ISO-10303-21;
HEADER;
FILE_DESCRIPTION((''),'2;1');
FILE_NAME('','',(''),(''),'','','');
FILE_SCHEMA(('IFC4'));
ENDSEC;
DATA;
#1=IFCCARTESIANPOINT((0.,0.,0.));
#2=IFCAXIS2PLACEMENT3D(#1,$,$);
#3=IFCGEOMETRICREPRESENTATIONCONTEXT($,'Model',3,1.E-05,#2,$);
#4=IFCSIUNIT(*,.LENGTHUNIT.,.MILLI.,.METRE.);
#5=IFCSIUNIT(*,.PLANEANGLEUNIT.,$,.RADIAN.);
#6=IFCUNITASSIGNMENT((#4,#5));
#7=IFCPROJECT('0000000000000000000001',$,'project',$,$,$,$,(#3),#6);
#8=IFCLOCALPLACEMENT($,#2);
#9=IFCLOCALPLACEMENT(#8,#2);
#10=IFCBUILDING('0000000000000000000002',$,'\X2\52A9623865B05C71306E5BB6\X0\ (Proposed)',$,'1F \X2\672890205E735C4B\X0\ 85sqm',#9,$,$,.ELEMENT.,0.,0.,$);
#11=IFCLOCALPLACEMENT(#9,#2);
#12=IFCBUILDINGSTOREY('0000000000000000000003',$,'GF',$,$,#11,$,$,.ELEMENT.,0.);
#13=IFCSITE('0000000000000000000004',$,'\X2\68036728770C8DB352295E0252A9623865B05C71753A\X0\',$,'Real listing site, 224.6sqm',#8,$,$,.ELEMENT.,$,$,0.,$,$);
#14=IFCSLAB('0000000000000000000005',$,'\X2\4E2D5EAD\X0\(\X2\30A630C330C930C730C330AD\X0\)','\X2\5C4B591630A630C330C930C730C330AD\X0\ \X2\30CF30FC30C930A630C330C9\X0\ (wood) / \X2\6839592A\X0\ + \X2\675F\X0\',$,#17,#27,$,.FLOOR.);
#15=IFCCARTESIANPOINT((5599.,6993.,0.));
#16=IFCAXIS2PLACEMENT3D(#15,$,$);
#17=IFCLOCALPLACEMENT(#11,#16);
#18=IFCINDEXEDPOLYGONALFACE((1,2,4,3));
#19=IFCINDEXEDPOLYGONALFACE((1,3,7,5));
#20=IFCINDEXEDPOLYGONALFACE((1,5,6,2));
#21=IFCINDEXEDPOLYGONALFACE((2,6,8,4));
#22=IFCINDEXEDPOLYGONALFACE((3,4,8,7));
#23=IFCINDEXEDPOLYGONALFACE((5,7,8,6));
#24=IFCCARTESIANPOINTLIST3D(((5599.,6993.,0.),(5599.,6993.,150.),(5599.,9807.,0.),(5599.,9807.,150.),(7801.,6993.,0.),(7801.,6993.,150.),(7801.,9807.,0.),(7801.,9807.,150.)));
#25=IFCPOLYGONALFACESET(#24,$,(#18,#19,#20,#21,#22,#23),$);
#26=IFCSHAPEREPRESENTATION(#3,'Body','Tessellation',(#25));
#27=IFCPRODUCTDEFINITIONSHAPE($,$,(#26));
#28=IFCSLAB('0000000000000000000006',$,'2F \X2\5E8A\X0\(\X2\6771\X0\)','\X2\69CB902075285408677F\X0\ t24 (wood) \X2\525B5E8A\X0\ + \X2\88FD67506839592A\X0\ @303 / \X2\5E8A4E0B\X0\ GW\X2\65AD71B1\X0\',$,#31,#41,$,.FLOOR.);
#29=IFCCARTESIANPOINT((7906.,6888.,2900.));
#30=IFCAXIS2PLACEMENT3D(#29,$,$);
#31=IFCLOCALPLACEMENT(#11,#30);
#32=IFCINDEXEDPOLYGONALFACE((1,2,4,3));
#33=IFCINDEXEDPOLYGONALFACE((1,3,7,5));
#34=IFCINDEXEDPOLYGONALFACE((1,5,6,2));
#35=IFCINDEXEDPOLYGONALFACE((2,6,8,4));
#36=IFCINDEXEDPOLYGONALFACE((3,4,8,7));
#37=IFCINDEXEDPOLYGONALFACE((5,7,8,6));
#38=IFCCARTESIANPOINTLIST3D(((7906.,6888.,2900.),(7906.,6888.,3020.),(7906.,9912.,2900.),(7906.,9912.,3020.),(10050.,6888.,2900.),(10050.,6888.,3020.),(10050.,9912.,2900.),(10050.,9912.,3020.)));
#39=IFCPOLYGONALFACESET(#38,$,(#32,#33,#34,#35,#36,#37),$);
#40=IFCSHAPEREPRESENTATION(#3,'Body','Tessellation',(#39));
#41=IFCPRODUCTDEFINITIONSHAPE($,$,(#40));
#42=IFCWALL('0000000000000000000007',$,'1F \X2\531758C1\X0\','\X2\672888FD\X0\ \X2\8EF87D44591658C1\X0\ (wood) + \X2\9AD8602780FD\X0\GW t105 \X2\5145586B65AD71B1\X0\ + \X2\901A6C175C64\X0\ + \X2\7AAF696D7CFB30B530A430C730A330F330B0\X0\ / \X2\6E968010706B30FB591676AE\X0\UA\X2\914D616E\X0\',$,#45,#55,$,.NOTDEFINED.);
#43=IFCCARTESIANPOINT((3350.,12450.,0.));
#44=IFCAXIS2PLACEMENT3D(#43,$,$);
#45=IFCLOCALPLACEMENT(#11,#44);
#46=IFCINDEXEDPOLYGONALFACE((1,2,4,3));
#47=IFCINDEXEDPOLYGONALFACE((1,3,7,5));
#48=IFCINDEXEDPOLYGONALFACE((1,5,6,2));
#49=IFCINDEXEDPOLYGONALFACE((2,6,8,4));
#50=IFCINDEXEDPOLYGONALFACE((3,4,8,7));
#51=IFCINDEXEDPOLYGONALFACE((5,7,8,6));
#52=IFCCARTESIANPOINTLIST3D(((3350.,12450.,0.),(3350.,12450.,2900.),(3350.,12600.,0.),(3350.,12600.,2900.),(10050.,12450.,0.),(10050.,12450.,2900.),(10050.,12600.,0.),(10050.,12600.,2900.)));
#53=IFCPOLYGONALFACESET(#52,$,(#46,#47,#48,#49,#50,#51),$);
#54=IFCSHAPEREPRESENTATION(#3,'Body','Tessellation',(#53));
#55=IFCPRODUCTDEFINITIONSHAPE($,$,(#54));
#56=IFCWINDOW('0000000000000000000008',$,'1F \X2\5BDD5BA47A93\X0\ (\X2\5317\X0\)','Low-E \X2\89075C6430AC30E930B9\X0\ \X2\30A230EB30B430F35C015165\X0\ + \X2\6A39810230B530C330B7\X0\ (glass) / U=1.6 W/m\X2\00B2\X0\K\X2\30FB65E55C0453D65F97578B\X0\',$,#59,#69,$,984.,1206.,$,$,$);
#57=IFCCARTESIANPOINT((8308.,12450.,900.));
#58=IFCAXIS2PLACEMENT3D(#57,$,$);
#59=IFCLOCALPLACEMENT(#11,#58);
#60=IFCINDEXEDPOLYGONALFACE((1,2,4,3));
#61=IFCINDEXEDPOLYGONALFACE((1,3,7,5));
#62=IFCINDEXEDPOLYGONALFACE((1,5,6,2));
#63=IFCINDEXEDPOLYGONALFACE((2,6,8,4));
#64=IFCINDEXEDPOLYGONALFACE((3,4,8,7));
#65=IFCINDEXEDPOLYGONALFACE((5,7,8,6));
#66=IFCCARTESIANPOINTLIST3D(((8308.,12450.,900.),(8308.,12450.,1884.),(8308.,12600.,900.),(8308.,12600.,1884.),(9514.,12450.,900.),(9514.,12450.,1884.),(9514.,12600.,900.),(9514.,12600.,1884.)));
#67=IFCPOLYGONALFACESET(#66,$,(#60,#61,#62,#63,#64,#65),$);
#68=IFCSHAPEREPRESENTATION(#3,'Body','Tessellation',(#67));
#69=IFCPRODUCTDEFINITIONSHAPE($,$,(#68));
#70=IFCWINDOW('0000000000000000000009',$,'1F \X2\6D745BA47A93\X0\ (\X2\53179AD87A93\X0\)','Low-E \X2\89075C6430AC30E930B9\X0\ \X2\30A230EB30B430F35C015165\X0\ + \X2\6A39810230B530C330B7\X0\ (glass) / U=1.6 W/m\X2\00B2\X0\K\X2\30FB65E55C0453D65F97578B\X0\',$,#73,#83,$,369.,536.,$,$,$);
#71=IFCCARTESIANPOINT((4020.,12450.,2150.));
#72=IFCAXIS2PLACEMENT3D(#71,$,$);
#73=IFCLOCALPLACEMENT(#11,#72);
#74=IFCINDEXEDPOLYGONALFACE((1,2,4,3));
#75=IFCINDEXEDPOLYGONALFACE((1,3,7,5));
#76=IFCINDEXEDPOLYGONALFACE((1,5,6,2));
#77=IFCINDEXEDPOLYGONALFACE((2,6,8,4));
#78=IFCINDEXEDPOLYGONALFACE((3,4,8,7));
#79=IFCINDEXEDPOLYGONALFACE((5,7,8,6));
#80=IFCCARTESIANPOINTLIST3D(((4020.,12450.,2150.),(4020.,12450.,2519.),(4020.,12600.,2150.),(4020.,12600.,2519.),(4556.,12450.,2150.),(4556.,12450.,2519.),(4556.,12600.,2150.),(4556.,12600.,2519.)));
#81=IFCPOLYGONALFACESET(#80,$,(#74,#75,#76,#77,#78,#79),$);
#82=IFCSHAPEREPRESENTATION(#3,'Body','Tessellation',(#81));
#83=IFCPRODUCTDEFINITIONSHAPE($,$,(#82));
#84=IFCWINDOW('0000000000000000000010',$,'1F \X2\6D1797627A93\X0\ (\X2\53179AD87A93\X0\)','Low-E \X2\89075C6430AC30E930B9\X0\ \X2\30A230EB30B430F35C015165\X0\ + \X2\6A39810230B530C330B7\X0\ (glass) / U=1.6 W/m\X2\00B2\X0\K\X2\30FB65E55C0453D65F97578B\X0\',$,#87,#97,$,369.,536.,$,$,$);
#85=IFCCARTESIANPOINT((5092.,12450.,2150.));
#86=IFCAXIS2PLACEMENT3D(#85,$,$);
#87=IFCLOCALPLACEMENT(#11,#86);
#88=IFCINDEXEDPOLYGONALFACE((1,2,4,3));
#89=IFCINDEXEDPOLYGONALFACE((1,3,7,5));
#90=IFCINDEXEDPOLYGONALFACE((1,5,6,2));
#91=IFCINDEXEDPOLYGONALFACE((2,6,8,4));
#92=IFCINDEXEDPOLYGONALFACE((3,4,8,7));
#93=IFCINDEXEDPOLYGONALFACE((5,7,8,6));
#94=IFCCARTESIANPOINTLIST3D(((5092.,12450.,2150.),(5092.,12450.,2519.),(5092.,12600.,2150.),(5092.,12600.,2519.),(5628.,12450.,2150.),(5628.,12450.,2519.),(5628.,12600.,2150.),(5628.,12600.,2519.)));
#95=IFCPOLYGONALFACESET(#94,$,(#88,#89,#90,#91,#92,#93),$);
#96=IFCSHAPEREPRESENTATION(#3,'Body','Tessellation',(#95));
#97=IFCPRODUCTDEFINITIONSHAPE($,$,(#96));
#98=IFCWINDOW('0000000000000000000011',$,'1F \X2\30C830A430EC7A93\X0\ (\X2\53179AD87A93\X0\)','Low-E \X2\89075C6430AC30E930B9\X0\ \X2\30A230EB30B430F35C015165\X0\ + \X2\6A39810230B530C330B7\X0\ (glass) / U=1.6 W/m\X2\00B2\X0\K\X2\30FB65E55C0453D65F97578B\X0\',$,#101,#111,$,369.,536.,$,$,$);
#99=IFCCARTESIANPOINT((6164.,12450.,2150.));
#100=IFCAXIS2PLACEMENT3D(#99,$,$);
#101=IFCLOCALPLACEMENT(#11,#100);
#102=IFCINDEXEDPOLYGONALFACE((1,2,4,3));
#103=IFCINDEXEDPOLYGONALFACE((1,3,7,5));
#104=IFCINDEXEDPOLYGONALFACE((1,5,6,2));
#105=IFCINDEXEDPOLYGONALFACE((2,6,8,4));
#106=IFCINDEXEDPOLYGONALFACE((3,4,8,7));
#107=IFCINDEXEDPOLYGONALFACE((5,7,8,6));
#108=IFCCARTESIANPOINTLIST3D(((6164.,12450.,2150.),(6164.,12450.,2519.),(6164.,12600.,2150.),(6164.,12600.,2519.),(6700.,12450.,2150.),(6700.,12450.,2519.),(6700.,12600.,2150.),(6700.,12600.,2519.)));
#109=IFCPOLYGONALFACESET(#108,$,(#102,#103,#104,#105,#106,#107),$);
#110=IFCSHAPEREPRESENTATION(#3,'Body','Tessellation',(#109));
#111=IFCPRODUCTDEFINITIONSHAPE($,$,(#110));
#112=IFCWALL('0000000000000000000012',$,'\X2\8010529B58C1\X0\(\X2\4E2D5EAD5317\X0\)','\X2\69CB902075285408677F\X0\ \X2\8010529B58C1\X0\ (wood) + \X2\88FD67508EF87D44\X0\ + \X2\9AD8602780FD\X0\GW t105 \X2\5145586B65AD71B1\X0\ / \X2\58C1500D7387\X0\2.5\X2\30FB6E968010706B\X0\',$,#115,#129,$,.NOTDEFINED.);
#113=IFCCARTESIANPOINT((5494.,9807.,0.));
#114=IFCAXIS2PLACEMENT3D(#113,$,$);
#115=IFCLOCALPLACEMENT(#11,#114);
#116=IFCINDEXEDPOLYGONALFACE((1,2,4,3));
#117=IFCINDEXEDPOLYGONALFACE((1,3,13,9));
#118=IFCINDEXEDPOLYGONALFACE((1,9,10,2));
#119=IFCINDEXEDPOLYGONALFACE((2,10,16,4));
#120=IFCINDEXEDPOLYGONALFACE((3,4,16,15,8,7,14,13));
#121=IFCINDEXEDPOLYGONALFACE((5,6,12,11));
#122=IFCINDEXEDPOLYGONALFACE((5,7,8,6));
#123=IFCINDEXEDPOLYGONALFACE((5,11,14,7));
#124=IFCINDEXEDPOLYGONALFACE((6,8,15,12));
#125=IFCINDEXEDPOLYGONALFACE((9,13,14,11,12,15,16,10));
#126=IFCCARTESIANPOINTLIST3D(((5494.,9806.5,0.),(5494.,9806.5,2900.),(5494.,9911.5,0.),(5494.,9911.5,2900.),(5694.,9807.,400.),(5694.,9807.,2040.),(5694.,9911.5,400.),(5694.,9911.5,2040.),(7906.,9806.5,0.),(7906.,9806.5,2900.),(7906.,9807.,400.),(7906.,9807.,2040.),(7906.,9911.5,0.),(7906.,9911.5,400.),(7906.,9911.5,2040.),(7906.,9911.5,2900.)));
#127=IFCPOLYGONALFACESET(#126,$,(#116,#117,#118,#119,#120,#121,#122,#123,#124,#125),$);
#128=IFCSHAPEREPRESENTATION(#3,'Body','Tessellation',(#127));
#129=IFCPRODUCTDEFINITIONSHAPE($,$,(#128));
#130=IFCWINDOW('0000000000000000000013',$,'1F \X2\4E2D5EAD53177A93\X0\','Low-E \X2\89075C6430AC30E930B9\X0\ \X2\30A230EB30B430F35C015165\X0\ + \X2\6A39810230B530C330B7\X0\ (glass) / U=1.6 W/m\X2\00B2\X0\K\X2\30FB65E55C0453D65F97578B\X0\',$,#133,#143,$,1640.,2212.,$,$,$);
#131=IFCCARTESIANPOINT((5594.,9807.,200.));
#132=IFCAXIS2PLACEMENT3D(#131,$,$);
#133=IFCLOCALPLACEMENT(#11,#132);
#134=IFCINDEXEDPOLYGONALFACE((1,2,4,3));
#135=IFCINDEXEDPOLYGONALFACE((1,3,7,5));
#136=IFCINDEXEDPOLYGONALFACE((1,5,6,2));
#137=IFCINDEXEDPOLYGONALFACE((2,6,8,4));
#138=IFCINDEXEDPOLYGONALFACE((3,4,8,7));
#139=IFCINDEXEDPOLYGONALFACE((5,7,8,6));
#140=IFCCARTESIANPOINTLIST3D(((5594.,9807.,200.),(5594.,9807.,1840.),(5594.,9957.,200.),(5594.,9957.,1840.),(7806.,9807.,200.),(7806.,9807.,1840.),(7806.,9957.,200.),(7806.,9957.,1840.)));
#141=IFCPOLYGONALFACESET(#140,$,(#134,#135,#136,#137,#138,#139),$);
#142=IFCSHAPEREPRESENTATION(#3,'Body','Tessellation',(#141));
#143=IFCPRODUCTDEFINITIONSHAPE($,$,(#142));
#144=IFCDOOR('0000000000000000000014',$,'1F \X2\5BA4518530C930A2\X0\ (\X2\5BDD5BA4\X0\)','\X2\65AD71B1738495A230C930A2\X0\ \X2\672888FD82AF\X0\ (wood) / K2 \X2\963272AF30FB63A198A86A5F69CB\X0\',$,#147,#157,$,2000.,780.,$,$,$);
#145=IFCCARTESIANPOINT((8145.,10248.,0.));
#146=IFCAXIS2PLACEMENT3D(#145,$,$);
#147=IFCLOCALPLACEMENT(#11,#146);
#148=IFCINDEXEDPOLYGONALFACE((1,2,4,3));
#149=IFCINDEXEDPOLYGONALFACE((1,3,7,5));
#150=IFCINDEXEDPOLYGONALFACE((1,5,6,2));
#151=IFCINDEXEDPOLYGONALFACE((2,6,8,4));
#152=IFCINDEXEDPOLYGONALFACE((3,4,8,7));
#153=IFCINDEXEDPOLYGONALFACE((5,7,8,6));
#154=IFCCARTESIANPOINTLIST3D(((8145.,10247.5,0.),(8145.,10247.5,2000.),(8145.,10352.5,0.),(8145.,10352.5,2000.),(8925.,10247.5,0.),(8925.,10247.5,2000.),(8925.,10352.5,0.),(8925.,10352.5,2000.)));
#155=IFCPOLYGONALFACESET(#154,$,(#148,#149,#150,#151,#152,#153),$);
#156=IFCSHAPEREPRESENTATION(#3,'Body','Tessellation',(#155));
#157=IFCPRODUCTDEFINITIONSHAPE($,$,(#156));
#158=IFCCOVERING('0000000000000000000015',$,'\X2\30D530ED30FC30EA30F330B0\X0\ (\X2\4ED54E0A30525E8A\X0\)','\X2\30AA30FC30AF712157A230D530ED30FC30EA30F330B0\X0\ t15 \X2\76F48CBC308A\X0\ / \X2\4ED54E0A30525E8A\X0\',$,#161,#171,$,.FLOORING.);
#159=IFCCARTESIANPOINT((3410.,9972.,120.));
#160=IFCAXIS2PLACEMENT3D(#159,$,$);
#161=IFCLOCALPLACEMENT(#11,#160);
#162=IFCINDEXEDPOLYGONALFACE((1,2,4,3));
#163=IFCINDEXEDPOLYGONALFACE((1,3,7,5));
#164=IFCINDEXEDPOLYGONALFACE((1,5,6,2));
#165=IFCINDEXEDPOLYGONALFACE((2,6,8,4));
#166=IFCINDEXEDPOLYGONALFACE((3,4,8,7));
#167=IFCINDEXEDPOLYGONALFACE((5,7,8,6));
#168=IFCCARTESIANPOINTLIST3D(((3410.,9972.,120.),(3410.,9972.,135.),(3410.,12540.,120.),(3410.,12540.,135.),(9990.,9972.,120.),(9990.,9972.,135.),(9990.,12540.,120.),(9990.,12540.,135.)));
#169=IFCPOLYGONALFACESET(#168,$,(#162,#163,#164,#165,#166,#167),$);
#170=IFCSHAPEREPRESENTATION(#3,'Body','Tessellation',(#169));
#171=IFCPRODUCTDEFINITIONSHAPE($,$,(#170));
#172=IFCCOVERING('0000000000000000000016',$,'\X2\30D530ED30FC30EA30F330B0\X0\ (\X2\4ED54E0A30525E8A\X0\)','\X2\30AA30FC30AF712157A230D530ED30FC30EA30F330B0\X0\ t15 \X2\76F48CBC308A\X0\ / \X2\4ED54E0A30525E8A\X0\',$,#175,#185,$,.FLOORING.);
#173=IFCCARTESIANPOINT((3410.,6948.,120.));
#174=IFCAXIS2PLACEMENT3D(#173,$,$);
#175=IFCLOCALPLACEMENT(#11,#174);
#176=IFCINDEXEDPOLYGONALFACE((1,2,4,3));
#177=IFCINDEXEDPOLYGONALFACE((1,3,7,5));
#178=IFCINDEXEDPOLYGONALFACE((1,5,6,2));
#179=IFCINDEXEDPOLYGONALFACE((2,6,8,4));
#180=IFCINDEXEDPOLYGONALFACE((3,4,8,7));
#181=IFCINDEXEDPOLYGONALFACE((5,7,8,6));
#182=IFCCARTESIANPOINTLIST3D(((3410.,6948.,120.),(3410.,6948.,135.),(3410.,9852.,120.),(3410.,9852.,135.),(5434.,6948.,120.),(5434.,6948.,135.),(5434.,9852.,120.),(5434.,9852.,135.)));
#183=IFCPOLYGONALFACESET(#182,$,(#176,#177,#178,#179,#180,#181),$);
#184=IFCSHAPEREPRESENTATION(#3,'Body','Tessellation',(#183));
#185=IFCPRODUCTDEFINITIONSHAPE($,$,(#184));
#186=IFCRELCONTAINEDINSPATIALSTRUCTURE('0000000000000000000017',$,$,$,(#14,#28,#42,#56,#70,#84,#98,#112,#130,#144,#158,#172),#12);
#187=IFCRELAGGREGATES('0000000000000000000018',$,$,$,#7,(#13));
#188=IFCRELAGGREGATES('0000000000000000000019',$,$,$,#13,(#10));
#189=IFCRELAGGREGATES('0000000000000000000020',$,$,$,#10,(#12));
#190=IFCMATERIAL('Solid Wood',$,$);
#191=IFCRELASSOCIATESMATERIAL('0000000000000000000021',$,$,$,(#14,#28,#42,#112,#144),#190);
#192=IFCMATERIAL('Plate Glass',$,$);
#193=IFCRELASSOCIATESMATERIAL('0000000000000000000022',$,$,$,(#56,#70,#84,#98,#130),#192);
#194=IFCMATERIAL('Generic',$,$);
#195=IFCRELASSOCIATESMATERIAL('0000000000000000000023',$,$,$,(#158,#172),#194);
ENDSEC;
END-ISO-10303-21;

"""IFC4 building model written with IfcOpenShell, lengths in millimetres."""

from ifc_helpers import new_model, si_unit, frame, frame_2d, origin, place, context, project, spatial, rectangle, extrude, material, element, fill, save


model = new_model("IFC4")

# Units and contexts
model_context = context("Model", 3, precision=1e-05, world=origin())
ifc_project = project(units=[si_unit("LENGTHUNIT", "METRE", prefix="MILLI"), si_unit("PLANEANGLEUNIT", "RADIAN")], contexts=[model_context])

# Site, building, storey
site_placement = place(None, origin())
site = spatial("IfcSite", under=ifc_project, at=site_placement, Name="栃木県足利市助戸新山町", ObjectType="Real listing site, 224.6sqm", CompositionType="ELEMENT", RefElevation=0.0)
building_placement = place(site_placement, origin())
building = spatial("IfcBuilding", under=site, at=building_placement, Name="助戸新山の家 (Proposed)", ObjectType="1F 木造平屋 85sqm", CompositionType="ELEMENT", ElevationOfRefHeight=0.0, ElevationOfTerrain=0.0)
storey_placement = place(building_placement, origin())
storey = spatial("IfcBuildingStorey", under=building, at=storey_placement, Name="GF", CompositionType="ELEMENT", Elevation=0.0)

# Slabs
ifc_material_1 = material(Name="Solid Wood")
slab_1_placement = place(storey_placement, frame((5599.0, 6993.0, 0.0)))
element("IfcSlab", 1, at=slab_1_placement, inside=storey, material=ifc_material_1, Name="中庭(ウッドデッキ)", Description="屋外ウッドデッキ ハードウッド (wood) / 根太 + 束", PredefinedType="FLOOR", context=model_context, shape_type="SweptSolid", body=[
    extrude(rectangle(XDim=2202.0, YDim=2814.0, at=frame_2d((1101.0, 1407.0))), frame((5599.0, 6993.0, 0.0)), (0.0, 0.0, 1.0), 150.0),
])
slab_2_placement = place(storey_placement, frame((7906.0, 6888.0, 2900.0)))
element("IfcSlab", 2, at=slab_2_placement, inside=storey, material=ifc_material_1, Name="2F 床(東)", Description="構造用合板 t24 (wood) 剛床 + 製材根太 @303 / 床下 GW断熱", PredefinedType="FLOOR", context=model_context, shape_type="SweptSolid", body=[
    extrude(rectangle(XDim=2144.0, YDim=3024.0, at=frame_2d((1072.0, 1512.0))), frame((7906.0, 6888.0, 2900.0)), (0.0, 0.0, 1.0), 120.0),
])

# Wall, openings, windows
wall_1_placement = place(storey_placement, frame((3350.0, 12450.0, 0.0)))
wall_1 = element("IfcWall", 3, at=wall_1_placement, inside=storey, material=ifc_material_1, Name="1F 北壁", Description="木製 軸組外壁 (wood) + 高性能GW t105 充填断熱 + 通気層 + 窯業系サイディング / 準耐火・外皮UA配慮", PredefinedType="NOTDEFINED", context=model_context, shape_type="SweptSolid", body=[
    extrude(rectangle(XDim=6700.0, YDim=150.0, at=frame_2d((3350.0, 75.0))), frame((3350.0, 12450.0, 0.0)), (0.0, 0.0, 1.0), 2900.0),
])
opening_1_placement = place(storey_placement, frame((8308.0, 12450.0, 900.0)))
opening_1 = element("IfcOpeningElement", 4, at=opening_1_placement, cuts=wall_1, PredefinedType="NOTDEFINED", context=model_context, shape_type="SweptSolid", body=[
    extrude(rectangle(XDim=1206.0, YDim=150.0, at=frame_2d((603.0, 75.0))), frame((8308.0, 12450.0, 900.0)), (0.0, 0.0, 1.0), 984.0),
])
opening_2_placement = place(storey_placement, frame((4020.0, 12450.0, 2150.0)))
opening_2 = element("IfcOpeningElement", 5, at=opening_2_placement, cuts=wall_1, PredefinedType="NOTDEFINED", context=model_context, shape_type="SweptSolid", body=[
    extrude(rectangle(XDim=536.0, YDim=150.0, at=frame_2d((268.0, 75.0))), frame((4020.0, 12450.0, 2150.0)), (0.0, 0.0, 1.0), 369.0),
])
opening_3_placement = place(storey_placement, frame((5092.0, 12450.0, 2150.0)))
opening_3 = element("IfcOpeningElement", 6, at=opening_3_placement, cuts=wall_1, PredefinedType="NOTDEFINED", context=model_context, shape_type="SweptSolid", body=[
    extrude(rectangle(XDim=536.0, YDim=150.0, at=frame_2d((268.0, 75.0))), frame((5092.0, 12450.0, 2150.0)), (0.0, 0.0, 1.0), 369.0),
])
opening_4_placement = place(storey_placement, frame((6164.0, 12450.0, 2150.0)))
opening_4 = element("IfcOpeningElement", 7, at=opening_4_placement, cuts=wall_1, PredefinedType="NOTDEFINED", context=model_context, shape_type="SweptSolid", body=[
    extrude(rectangle(XDim=536.0, YDim=150.0, at=frame_2d((268.0, 75.0))), frame((6164.0, 12450.0, 2150.0)), (0.0, 0.0, 1.0), 369.0),
])
ifc_material_2 = material(Name="Plate Glass")
window_1_placement = place(storey_placement, frame((8308.0, 12450.0, 900.0)))
window_1 = element("IfcWindow", 8, at=window_1_placement, inside=storey, material=ifc_material_2, Name="1F 寝室窓 (北)", Description="Low-E 複層ガラス アルゴン封入 + 樹脂サッシ (glass) / U=1.6 W/m²K・日射取得型", OverallHeight=984.0, OverallWidth=1206.0, context=model_context, shape_type="SweptSolid", body=[
    extrude(rectangle(XDim=1206.0, YDim=150.0, at=frame_2d((603.0, 75.0))), frame((8308.0, 12450.0, 900.0)), (0.0, 0.0, 1.0), 984.0),
])
fill(opening_1, window_1)
window_2_placement = place(storey_placement, frame((4020.0, 12450.0, 2150.0)))
window_2 = element("IfcWindow", 9, at=window_2_placement, inside=storey, material=ifc_material_2, Name="1F 浴室窓 (北高窓)", Description="Low-E 複層ガラス アルゴン封入 + 樹脂サッシ (glass) / U=1.6 W/m²K・日射取得型", OverallHeight=369.0, OverallWidth=536.0, context=model_context, shape_type="SweptSolid", body=[
    extrude(rectangle(XDim=536.0, YDim=150.0, at=frame_2d((268.0, 75.0))), frame((4020.0, 12450.0, 2150.0)), (0.0, 0.0, 1.0), 369.0),
])
fill(opening_2, window_2)
window_3_placement = place(storey_placement, frame((5092.0, 12450.0, 2150.0)))
window_3 = element("IfcWindow", 10, at=window_3_placement, inside=storey, material=ifc_material_2, Name="1F 洗面窓 (北高窓)", Description="Low-E 複層ガラス アルゴン封入 + 樹脂サッシ (glass) / U=1.6 W/m²K・日射取得型", OverallHeight=369.0, OverallWidth=536.0, context=model_context, shape_type="SweptSolid", body=[
    extrude(rectangle(XDim=536.0, YDim=150.0, at=frame_2d((268.0, 75.0))), frame((5092.0, 12450.0, 2150.0)), (0.0, 0.0, 1.0), 369.0),
])
fill(opening_3, window_3)
window_4_placement = place(storey_placement, frame((6164.0, 12450.0, 2150.0)))
window_4 = element("IfcWindow", 11, at=window_4_placement, inside=storey, material=ifc_material_2, Name="1F トイレ窓 (北高窓)", Description="Low-E 複層ガラス アルゴン封入 + 樹脂サッシ (glass) / U=1.6 W/m²K・日射取得型", OverallHeight=369.0, OverallWidth=536.0, context=model_context, shape_type="SweptSolid", body=[
    extrude(rectangle(XDim=536.0, YDim=150.0, at=frame_2d((268.0, 75.0))), frame((6164.0, 12450.0, 2150.0)), (0.0, 0.0, 1.0), 369.0),
])
fill(opening_4, window_4)

# Wall, opening, window
wall_2_placement = place(storey_placement, frame((5494.0, 9807.0, 0.0)))
wall_2 = element("IfcWall", 12, at=wall_2_placement, inside=storey, material=ifc_material_1, Name="耐力壁(中庭北)", Description="構造用合板 耐力壁 (wood) + 製材軸組 + 高性能GW t105 充填断熱 / 壁倍率2.5・準耐火", PredefinedType="NOTDEFINED", context=model_context, shape_type="SweptSolid", body=[
    extrude(rectangle(XDim=2412.0, YDim=105.0, at=frame_2d((1206.0, 52.0))), frame((5494.0, 9807.0, 0.0)), (0.0, 0.0, 1.0), 2900.0),
])
opening_5_placement = place(storey_placement, frame((5594.0, 9807.0, 200.0)))
opening_5 = element("IfcOpeningElement", 13, at=opening_5_placement, cuts=wall_2, PredefinedType="NOTDEFINED", context=model_context, shape_type="SweptSolid", body=[
    extrude(rectangle(XDim=2212.0, YDim=150.0, at=frame_2d((1106.0, 75.0))), frame((5594.0, 9807.0, 200.0)), (0.0, 0.0, 1.0), 1640.0),
])
window_5_placement = place(storey_placement, frame((5594.0, 9807.0, 200.0)))
window_5 = element("IfcWindow", 14, at=window_5_placement, inside=storey, material=ifc_material_2, Name="1F 中庭北窓", Description="Low-E 複層ガラス アルゴン封入 + 樹脂サッシ (glass) / U=1.6 W/m²K・日射取得型", OverallHeight=1640.0, OverallWidth=2212.0, context=model_context, shape_type="SweptSolid", body=[
    extrude(rectangle(XDim=2212.0, YDim=150.0, at=frame_2d((1106.0, 75.0))), frame((5594.0, 9807.0, 200.0)), (0.0, 0.0, 1.0), 1640.0),
])
fill(opening_5, window_5)

# Door
door_1_placement = place(storey_placement, frame((8145.0, 10248.0, 0.0)))
element("IfcDoor", 15, at=door_1_placement, inside=storey, material=ifc_material_1, Name="1F 室内ドア (寝室)", Description="断熱玄関ドア 木製芯 (wood) / K2 防犯・採風機構", OverallHeight=2000.0, OverallWidth=780.0, context=model_context, shape_type="SweptSolid", body=[
    extrude(rectangle(XDim=780.0, YDim=105.0, at=frame_2d((390.0, 52.0))), frame((8145.0, 10248.0, 0.0)), (0.0, 0.0, 1.0), 2000.0),
])

# Coverings
ifc_material_3 = material(Name="Generic")
covering_1_placement = place(storey_placement, frame((3410.0, 9972.0, 120.0)))
element("IfcCovering", 16, at=covering_1_placement, inside=storey, material=ifc_material_3, Name="フローリング (仕上げ床)", Description="オーク無垢フローリング t15 直貼り / 仕上げ床", PredefinedType="FLOORING", context=model_context, shape_type="SweptSolid", body=[
    extrude(rectangle(XDim=6580.0, YDim=2568.0, at=frame_2d((3290.0, 1284.0))), frame((3410.0, 9972.0, 120.0)), (0.0, 0.0, 1.0), 15.0),
])
covering_2_placement = place(storey_placement, frame((3410.0, 6948.0, 120.0)))
element("IfcCovering", 17, at=covering_2_placement, inside=storey, material=ifc_material_3, Name="フローリング (仕上げ床)", Description="オーク無垢フローリング t15 直貼り / 仕上げ床", PredefinedType="FLOORING", context=model_context, shape_type="SweptSolid", body=[
    extrude(rectangle(XDim=2024.0, YDim=2904.0, at=frame_2d((1012.0, 1452.0))), frame((3410.0, 6948.0, 120.0)), (0.0, 0.0, 1.0), 15.0),
])

save(model, "model.ifc")
